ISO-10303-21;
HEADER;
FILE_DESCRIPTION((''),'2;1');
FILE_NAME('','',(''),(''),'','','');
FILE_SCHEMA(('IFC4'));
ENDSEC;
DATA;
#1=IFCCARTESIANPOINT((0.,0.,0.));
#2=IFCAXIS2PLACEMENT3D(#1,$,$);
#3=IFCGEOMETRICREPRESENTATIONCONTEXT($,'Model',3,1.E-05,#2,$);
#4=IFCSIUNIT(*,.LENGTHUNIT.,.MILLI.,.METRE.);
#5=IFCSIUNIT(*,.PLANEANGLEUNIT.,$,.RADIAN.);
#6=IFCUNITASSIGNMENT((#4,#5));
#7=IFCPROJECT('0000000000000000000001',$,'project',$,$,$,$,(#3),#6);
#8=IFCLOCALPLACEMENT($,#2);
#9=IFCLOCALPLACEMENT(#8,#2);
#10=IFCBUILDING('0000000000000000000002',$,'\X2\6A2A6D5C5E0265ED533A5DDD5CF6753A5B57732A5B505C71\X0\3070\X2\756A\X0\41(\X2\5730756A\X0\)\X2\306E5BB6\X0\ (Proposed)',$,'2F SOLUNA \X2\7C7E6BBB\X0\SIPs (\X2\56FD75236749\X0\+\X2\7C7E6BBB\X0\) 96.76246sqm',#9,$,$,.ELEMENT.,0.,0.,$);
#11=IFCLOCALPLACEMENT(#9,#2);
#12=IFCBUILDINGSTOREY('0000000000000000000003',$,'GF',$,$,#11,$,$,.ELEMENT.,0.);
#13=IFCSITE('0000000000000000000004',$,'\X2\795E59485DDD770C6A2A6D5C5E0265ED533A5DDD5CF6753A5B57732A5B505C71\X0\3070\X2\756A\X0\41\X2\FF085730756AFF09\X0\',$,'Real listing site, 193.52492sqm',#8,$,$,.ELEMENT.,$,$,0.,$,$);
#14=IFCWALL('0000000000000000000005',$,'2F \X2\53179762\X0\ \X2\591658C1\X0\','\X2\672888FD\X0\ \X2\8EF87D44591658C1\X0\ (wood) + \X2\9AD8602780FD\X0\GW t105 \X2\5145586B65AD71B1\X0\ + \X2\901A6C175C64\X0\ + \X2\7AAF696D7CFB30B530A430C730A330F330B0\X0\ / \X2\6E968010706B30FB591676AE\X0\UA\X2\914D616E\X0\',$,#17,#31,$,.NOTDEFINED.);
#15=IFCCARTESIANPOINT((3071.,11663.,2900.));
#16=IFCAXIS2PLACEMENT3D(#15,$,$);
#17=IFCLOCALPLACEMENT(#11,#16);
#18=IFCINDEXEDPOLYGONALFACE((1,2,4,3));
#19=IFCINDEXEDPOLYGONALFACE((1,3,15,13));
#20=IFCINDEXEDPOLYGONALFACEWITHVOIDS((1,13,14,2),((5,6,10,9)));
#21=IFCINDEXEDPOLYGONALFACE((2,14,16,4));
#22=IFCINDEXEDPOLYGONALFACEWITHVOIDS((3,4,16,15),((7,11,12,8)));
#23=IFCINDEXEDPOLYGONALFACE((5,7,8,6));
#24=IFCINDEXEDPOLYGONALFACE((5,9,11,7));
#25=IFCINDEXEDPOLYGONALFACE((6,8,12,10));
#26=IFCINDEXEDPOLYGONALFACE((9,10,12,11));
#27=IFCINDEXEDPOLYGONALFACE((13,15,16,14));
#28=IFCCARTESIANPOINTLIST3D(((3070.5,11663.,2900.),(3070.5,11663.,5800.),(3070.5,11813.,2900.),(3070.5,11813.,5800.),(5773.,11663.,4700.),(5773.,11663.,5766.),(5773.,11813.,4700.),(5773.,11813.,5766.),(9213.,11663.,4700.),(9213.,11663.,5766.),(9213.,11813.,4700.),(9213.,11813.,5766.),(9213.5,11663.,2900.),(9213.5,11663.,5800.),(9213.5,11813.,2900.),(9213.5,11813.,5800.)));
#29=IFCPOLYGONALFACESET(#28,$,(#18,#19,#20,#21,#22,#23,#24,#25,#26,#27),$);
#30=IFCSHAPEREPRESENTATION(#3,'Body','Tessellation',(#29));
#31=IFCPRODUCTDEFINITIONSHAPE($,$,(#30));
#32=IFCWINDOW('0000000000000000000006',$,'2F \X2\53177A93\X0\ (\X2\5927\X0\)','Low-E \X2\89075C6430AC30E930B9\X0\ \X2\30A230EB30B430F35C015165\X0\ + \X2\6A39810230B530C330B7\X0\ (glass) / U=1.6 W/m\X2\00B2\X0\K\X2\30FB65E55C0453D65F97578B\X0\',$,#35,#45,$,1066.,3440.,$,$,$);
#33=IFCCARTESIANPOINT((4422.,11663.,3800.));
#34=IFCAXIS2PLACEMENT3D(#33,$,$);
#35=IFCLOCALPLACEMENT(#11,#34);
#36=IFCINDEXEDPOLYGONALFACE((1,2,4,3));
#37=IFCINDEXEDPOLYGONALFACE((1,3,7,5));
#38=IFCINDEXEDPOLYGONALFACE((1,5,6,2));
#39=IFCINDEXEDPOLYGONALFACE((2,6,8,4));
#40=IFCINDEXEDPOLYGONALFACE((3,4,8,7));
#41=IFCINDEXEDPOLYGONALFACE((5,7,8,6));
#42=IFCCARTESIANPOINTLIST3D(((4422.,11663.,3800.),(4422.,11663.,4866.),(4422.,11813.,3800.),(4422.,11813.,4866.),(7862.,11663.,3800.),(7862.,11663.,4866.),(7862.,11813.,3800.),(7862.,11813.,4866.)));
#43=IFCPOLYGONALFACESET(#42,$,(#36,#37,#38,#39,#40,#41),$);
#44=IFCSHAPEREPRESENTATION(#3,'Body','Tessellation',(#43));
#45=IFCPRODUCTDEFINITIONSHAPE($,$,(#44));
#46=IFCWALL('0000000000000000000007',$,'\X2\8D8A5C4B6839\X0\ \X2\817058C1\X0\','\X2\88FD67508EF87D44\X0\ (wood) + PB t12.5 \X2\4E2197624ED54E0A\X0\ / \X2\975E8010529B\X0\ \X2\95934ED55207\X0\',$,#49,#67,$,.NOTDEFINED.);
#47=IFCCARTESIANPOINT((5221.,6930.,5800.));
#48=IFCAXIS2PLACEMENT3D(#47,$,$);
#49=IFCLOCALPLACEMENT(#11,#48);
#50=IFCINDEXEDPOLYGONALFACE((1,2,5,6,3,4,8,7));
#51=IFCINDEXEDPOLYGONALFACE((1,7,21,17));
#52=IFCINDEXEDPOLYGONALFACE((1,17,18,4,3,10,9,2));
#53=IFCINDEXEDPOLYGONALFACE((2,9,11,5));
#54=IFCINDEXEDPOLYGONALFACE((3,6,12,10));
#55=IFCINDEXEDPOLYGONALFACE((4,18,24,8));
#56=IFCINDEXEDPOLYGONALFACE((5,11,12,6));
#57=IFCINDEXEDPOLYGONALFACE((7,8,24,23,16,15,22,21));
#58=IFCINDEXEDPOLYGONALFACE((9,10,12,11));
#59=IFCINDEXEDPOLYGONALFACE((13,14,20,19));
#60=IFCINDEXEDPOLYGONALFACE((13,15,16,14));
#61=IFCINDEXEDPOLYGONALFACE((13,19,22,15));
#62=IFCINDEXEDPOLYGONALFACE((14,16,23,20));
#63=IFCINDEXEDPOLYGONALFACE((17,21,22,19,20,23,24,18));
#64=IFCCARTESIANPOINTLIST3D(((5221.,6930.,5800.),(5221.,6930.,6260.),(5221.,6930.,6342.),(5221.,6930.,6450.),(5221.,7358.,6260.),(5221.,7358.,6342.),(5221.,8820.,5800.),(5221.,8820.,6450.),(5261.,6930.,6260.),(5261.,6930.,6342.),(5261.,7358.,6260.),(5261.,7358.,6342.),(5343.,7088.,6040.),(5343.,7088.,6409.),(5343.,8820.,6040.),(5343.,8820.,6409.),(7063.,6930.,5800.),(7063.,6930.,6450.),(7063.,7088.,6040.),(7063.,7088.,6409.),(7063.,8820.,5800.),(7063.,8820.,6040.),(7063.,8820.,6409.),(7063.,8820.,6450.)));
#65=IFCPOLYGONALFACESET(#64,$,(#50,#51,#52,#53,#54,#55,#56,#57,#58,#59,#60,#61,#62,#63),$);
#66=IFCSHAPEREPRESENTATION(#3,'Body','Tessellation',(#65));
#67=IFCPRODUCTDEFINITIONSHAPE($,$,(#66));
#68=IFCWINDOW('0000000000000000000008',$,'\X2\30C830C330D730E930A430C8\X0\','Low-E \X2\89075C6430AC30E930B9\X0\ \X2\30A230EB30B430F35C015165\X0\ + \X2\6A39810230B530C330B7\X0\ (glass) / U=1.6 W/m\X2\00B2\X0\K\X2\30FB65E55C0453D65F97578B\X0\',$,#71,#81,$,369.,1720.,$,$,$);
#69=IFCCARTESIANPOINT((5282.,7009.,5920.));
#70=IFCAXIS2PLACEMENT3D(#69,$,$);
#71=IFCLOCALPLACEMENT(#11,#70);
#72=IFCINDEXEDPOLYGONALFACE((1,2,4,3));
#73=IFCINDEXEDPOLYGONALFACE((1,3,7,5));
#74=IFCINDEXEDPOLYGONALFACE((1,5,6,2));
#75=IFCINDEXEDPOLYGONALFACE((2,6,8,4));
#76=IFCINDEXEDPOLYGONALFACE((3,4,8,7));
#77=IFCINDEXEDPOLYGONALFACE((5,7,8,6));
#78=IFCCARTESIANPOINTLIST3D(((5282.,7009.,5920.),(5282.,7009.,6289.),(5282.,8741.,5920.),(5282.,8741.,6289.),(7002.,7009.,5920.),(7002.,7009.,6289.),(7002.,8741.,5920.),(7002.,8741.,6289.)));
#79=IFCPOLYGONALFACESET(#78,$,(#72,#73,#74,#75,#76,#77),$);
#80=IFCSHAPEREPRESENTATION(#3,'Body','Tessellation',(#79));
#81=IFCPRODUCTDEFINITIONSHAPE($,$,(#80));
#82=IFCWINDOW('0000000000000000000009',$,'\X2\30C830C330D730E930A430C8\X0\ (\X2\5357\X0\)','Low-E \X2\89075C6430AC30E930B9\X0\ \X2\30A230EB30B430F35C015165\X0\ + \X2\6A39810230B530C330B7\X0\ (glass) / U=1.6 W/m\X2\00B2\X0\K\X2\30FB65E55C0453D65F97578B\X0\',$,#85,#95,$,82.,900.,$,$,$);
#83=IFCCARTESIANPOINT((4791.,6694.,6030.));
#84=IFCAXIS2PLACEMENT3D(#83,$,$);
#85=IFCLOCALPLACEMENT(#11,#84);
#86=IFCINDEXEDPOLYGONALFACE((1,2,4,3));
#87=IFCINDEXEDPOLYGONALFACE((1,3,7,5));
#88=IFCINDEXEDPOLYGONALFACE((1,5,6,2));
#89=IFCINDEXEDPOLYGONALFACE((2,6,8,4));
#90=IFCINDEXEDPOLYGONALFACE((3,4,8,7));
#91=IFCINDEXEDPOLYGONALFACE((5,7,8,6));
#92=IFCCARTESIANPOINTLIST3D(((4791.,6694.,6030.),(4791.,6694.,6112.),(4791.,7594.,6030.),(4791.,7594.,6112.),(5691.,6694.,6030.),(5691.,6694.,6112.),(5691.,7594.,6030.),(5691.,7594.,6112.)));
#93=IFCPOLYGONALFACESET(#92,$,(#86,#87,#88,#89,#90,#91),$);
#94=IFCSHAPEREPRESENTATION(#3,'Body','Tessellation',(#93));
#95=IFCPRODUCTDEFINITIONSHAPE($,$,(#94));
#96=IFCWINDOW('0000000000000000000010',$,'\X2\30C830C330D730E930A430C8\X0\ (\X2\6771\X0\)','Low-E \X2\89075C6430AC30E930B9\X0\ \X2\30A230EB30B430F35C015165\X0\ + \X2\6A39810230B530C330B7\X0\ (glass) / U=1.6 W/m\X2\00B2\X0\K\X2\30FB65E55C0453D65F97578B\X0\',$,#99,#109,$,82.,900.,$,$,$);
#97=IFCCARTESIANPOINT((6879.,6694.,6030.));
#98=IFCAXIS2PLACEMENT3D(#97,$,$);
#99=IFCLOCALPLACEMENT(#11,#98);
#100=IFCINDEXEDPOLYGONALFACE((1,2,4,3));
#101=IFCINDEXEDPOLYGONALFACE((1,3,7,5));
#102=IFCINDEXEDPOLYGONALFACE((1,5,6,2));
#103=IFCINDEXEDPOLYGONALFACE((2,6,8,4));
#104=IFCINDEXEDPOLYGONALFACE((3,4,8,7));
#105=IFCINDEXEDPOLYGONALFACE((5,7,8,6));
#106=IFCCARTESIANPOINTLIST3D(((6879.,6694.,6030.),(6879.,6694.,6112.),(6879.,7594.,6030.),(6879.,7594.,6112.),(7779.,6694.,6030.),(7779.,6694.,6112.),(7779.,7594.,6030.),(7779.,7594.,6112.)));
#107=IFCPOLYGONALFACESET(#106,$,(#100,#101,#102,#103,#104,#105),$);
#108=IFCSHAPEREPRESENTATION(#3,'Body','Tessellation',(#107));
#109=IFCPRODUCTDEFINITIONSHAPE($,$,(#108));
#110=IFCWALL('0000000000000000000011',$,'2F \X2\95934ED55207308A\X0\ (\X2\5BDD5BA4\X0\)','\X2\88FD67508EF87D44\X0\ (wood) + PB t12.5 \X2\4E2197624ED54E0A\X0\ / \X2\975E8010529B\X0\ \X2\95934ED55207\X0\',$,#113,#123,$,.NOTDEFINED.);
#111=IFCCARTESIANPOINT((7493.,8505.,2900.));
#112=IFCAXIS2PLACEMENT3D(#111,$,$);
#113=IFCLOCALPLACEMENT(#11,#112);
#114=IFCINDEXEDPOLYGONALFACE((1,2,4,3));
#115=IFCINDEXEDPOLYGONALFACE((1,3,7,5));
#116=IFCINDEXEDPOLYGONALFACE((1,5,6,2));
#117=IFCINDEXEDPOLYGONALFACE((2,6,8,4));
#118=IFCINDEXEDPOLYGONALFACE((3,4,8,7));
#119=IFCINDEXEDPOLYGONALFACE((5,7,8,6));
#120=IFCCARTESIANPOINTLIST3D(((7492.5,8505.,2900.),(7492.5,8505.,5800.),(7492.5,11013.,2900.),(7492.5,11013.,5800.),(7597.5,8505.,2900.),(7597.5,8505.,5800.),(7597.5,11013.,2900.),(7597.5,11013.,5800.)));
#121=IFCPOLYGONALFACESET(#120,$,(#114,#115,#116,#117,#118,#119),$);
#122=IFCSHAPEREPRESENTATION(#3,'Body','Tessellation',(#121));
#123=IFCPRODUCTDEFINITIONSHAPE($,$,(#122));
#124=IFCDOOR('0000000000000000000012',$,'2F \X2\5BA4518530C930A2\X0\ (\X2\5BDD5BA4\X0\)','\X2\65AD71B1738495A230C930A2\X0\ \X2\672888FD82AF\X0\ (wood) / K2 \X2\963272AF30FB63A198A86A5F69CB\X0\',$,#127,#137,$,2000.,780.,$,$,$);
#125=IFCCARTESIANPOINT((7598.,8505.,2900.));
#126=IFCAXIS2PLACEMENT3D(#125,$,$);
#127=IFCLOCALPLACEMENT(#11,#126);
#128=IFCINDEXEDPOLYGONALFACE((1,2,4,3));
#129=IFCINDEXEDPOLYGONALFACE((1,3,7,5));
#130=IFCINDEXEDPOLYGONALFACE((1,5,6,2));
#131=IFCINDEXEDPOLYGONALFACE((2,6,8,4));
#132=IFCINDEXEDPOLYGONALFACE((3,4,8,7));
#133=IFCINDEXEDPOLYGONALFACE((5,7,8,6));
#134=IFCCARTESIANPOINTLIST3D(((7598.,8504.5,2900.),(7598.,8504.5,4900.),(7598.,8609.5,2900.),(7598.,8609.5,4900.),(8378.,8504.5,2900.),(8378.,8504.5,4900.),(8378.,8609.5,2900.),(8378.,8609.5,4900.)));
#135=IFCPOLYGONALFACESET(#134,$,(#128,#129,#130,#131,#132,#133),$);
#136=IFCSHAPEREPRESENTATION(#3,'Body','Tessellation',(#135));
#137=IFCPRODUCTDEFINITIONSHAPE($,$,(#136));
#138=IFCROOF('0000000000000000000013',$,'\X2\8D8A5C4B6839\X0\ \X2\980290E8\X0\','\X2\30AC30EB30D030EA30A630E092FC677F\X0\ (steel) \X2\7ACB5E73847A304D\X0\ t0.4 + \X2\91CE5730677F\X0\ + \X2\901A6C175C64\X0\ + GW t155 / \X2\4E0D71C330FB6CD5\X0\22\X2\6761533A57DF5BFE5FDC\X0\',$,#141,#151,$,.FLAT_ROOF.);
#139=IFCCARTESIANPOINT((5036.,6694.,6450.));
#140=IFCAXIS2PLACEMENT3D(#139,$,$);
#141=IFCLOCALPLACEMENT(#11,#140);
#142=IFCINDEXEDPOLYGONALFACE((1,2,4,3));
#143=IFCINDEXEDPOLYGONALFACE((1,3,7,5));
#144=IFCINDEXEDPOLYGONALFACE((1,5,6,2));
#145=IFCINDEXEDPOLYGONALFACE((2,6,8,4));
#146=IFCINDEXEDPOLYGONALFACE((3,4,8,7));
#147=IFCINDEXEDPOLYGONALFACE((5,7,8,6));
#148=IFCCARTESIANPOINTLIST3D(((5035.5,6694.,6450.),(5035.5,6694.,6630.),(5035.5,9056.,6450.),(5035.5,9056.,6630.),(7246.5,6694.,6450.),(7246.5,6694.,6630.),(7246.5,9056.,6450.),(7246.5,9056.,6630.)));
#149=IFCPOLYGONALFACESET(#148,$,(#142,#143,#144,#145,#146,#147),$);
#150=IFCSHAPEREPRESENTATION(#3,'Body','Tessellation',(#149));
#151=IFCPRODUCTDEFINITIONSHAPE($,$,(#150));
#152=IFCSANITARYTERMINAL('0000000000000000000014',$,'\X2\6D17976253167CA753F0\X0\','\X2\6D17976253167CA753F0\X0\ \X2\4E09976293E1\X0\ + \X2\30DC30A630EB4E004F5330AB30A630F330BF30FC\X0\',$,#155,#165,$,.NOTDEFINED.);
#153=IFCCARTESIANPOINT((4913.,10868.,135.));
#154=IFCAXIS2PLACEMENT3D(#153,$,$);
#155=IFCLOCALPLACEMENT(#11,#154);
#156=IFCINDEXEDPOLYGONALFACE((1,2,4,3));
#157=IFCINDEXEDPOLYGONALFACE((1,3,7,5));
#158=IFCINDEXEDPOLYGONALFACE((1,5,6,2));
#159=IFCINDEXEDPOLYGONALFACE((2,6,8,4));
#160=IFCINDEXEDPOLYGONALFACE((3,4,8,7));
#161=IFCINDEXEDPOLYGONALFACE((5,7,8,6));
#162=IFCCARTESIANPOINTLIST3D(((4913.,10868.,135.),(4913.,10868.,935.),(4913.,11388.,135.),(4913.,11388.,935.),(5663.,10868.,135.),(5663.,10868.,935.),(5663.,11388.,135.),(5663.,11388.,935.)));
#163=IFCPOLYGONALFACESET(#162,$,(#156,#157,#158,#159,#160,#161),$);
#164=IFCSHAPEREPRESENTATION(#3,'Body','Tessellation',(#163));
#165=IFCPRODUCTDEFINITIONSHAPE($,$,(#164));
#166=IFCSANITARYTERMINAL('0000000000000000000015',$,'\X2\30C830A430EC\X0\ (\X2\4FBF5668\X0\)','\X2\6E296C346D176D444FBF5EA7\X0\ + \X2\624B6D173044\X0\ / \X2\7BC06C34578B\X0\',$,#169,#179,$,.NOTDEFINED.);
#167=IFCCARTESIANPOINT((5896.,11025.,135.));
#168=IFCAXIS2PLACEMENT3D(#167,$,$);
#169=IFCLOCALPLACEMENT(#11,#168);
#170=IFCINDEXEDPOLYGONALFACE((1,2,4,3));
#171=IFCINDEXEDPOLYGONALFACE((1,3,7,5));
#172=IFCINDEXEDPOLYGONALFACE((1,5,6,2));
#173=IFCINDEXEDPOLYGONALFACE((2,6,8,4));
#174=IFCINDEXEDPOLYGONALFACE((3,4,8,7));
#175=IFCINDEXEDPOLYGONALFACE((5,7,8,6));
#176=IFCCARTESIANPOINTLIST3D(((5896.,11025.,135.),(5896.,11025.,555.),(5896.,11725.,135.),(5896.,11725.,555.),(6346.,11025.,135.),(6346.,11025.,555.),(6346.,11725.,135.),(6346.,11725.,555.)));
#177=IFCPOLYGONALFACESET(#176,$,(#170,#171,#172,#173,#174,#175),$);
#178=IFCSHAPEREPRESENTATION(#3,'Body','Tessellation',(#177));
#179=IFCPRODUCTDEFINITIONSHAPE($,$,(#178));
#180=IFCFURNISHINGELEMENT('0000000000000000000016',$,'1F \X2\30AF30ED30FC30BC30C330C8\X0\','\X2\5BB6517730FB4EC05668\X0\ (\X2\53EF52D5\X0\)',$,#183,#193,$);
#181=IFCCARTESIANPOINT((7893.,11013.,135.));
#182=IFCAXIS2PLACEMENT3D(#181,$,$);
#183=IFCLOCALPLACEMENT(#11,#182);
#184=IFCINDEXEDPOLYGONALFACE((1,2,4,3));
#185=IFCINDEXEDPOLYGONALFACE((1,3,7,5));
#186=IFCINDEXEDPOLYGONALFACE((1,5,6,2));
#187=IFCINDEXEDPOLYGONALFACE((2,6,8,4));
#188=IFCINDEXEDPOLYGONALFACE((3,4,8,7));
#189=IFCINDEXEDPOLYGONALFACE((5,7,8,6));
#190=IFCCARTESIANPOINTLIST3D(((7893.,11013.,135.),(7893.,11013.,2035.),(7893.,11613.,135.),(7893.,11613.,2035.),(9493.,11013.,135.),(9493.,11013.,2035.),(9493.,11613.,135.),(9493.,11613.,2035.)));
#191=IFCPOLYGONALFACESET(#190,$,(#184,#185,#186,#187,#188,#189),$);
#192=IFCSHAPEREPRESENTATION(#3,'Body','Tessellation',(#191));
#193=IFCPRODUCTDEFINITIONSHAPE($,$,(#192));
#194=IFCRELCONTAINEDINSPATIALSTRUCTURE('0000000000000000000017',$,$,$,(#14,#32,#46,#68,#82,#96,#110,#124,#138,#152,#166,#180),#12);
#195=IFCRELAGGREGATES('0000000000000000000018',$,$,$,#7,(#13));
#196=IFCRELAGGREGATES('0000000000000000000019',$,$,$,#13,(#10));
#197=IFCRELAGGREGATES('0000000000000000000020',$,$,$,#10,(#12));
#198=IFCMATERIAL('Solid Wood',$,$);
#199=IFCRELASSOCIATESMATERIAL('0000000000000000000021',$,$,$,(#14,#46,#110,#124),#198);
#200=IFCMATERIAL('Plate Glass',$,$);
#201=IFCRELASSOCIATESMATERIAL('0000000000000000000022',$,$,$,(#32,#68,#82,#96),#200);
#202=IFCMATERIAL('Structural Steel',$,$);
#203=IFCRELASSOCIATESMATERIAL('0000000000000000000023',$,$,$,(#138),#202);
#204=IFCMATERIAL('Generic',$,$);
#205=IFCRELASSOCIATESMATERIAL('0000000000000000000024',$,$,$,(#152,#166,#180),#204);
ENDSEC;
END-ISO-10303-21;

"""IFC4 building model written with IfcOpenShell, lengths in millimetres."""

from ifc_helpers import new_model, si_unit, frame, frame_2d, origin, place, context, project, spatial, rectangle, extrude, material, element, fill, save


model = new_model("IFC4")

# Units and contexts
model_context = context("Model", 3, precision=1e-05, world=origin())
ifc_project = project(units=[si_unit("LENGTHUNIT", "METRE", prefix="MILLI"), si_unit("PLANEANGLEUNIT", "RADIAN")], contexts=[model_context])

# Site, building, storey
site_placement = place(None, origin())
site = spatial("IfcSite", under=ifc_project, at=site_placement, Name="神奈川県横浜市旭区川島町字猪子山3070番41（地番）", ObjectType="Real listing site, 193.52492sqm", CompositionType="ELEMENT", RefElevation=0.0)
building_placement = place(site_placement, origin())
building = spatial("IfcBuilding", under=site, at=building_placement, Name="横浜市旭区川島町字猪子山3070番41(地番)の家 (Proposed)", ObjectType="2F SOLUNA 籾殻SIPs (国産杉+籾殻) 96.76246sqm", CompositionType="ELEMENT", ElevationOfRefHeight=0.0, ElevationOfTerrain=0.0)
storey_placement = place(building_placement, origin())
storey = spatial("IfcBuildingStorey", under=building, at=storey_placement, Name="GF", CompositionType="ELEMENT", Elevation=0.0)

# Wall, opening, window
ifc_material_1 = material(Name="Solid Wood")
wall_1_placement = place(storey_placement, frame((3071.0, 11663.0, 2900.0)))
wall_1 = element("IfcWall", 1, at=wall_1_placement, inside=storey, material=ifc_material_1, Name="2F 北面 外壁", Description="木製 軸組外壁 (wood) + 高性能GW t105 充填断熱 + 通気層 + 窯業系サイディング / 準耐火・外皮UA配慮", PredefinedType="NOTDEFINED", context=model_context, shape_type="SweptSolid", body=[
    extrude(rectangle(XDim=6143.0, YDim=150.0, at=frame_2d((3071.0, 75.0))), frame((3071.0, 11663.0, 2900.0)), (0.0, 0.0, 1.0), 2900.0),
])
opening_1_placement = place(storey_placement, frame((4422.0, 11663.0, 3800.0)))
opening_1 = element("IfcOpeningElement", 2, at=opening_1_placement, cuts=wall_1, PredefinedType="NOTDEFINED", context=model_context, shape_type="SweptSolid", body=[
    extrude(rectangle(XDim=3440.0, YDim=150.0, at=frame_2d((1720.0, 75.0))), frame((4422.0, 11663.0, 3800.0)), (0.0, 0.0, 1.0), 1066.0),
])
ifc_material_2 = material(Name="Plate Glass")
window_1_placement = place(storey_placement, frame((4422.0, 11663.0, 3800.0)))
window_1 = element("IfcWindow", 3, at=window_1_placement, inside=storey, material=ifc_material_2, Name="2F 北窓 (大)", Description="Low-E 複層ガラス アルゴン封入 + 樹脂サッシ (glass) / U=1.6 W/m²K・日射取得型", OverallHeight=1066.0, OverallWidth=3440.0, context=model_context, shape_type="SweptSolid", body=[
    extrude(rectangle(XDim=3440.0, YDim=150.0, at=frame_2d((1720.0, 75.0))), frame((4422.0, 11663.0, 3800.0)), (0.0, 0.0, 1.0), 1066.0),
])
fill(opening_1, window_1)

# Wall, openings, windows
wall_2_placement = place(storey_placement, frame((5221.0, 6930.0, 5800.0)))
wall_2 = element("IfcWall", 4, at=wall_2_placement, inside=storey, material=ifc_material_1, Name="越屋根 腰壁", Description="製材軸組 (wood) + PB t12.5 両面仕上 / 非耐力 間仕切", PredefinedType="NOTDEFINED", context=model_context, shape_type="SweptSolid", body=[
    extrude(rectangle(XDim=1842.0, YDim=1890.0, at=frame_2d((921.0, 945.0))), frame((5221.0, 6930.0, 5800.0)), (0.0, 0.0, 1.0), 650.0),
])
opening_2_placement = place(storey_placement, frame((5282.0, 7009.0, 5920.0)))
opening_2 = element("IfcOpeningElement", 5, at=opening_2_placement, cuts=wall_2, PredefinedType="NOTDEFINED", context=model_context, shape_type="SweptSolid", body=[
    extrude(rectangle(XDim=1720.0, YDim=1732.0, at=frame_2d((860.0, 866.0))), frame((5282.0, 7009.0, 5920.0)), (0.0, 0.0, 1.0), 369.0),
])
opening_3_placement = place(storey_placement, frame((4791.0, 6694.0, 6030.0)))
opening_3 = element("IfcOpeningElement", 6, at=opening_3_placement, cuts=wall_2, PredefinedType="NOTDEFINED", context=model_context, shape_type="SweptSolid", body=[
    extrude(rectangle(XDim=900.0, YDim=900.0, at=frame_2d((450.0, 450.0))), frame((4791.0, 6694.0, 6030.0)), (0.0, 0.0, 1.0), 82.0),
])
opening_4_placement = place(storey_placement, frame((6879.0, 6694.0, 6030.0)))
opening_4 = element("IfcOpeningElement", 7, at=opening_4_placement, cuts=wall_2, PredefinedType="NOTDEFINED", context=model_context, shape_type="SweptSolid", body=[
    extrude(rectangle(XDim=900.0, YDim=900.0, at=frame_2d((450.0, 450.0))), frame((6879.0, 6694.0, 6030.0)), (0.0, 0.0, 1.0), 82.0),
])
window_2_placement = place(storey_placement, frame((5282.0, 7009.0, 5920.0)))
window_2 = element("IfcWindow", 8, at=window_2_placement, inside=storey, material=ifc_material_2, Name="トップライト", Description="Low-E 複層ガラス アルゴン封入 + 樹脂サッシ (glass) / U=1.6 W/m²K・日射取得型", OverallHeight=369.0, OverallWidth=1720.0, context=model_context, shape_type="SweptSolid", body=[
    extrude(rectangle(XDim=1720.0, YDim=1732.0, at=frame_2d((860.0, 866.0))), frame((5282.0, 7009.0, 5920.0)), (0.0, 0.0, 1.0), 369.0),
])
fill(opening_2, window_2)
window_3_placement = place(storey_placement, frame((4791.0, 6694.0, 6030.0)))
window_3 = element("IfcWindow", 9, at=window_3_placement, inside=storey, material=ifc_material_2, Name="トップライト (南)", Description="Low-E 複層ガラス アルゴン封入 + 樹脂サッシ (glass) / U=1.6 W/m²K・日射取得型", OverallHeight=82.0, OverallWidth=900.0, context=model_context, shape_type="SweptSolid", body=[
    extrude(rectangle(XDim=900.0, YDim=900.0, at=frame_2d((450.0, 450.0))), frame((4791.0, 6694.0, 6030.0)), (0.0, 0.0, 1.0), 82.0),
])
fill(opening_3, window_3)
window_4_placement = place(storey_placement, frame((6879.0, 6694.0, 6030.0)))
window_4 = element("IfcWindow", 10, at=window_4_placement, inside=storey, material=ifc_material_2, Name="トップライト (東)", Description="Low-E 複層ガラス アルゴン封入 + 樹脂サッシ (glass) / U=1.6 W/m²K・日射取得型", OverallHeight=82.0, OverallWidth=900.0, context=model_context, shape_type="SweptSolid", body=[
    extrude(rectangle(XDim=900.0, YDim=900.0, at=frame_2d((450.0, 450.0))), frame((6879.0, 6694.0, 6030.0)), (0.0, 0.0, 1.0), 82.0),
])
fill(opening_4, window_4)

# Wall
wall_3_placement = place(storey_placement, frame((7493.0, 8505.0, 2900.0)))
element("IfcWall", 11, at=wall_3_placement, inside=storey, material=ifc_material_1, Name="2F 間仕切り (寝室)", Description="製材軸組 (wood) + PB t12.5 両面仕上 / 非耐力 間仕切", PredefinedType="NOTDEFINED", context=model_context, shape_type="SweptSolid", body=[
    extrude(rectangle(XDim=105.0, YDim=2508.0, at=frame_2d((52.0, 1254.0))), frame((7493.0, 8505.0, 2900.0)), (0.0, 0.0, 1.0), 2900.0),
])

# Door
door_placement = place(storey_placement, frame((7598.0, 8505.0, 2900.0)))
element("IfcDoor", 12, at=door_placement, inside=storey, material=ifc_material_1, Name="2F 室内ドア (寝室)", Description="断熱玄関ドア 木製芯 (wood) / K2 防犯・採風機構", OverallHeight=2000.0, OverallWidth=780.0, context=model_context, shape_type="SweptSolid", body=[
    extrude(rectangle(XDim=780.0, YDim=105.0, at=frame_2d((390.0, 52.0))), frame((7598.0, 8505.0, 2900.0)), (0.0, 0.0, 1.0), 2000.0),
])

# Roof
ifc_material_3 = material(Name="Structural Steel")
roof_placement = place(storey_placement, frame((5036.0, 6694.0, 6450.0)))
element("IfcRoof", 13, at=roof_placement, inside=storey, material=ifc_material_3, Name="越屋根 頂部", Description="ガルバリウム鋼板 (steel) 立平葺き t0.4 + 野地板 + 通気層 + GW t155 / 不燃・法22条区域対応", PredefinedType="FLAT_ROOF", context=model_context, shape_type="SweptSolid", body=[
    extrude(rectangle(XDim=2211.0, YDim=2362.0, at=frame_2d((1105.0, 1181.0))), frame((5036.0, 6694.0, 6450.0)), (0.0, 0.0, 1.0), 180.0),
])

# Sanitary terminals
ifc_material_4 = material(Name="Generic")
sanitary_terminal_1_placement = place(storey_placement, frame((4913.0, 10868.0, 135.0)))
element("IfcSanitaryTerminal", 14, at=sanitary_terminal_1_placement, inside=storey, material=ifc_material_4, Name="洗面化粧台", Description="洗面化粧台 三面鏡 + ボウル一体カウンター", PredefinedType="NOTDEFINED", context=model_context, shape_type="SweptSolid", body=[
    extrude(rectangle(XDim=750.0, YDim=520.0, at=frame_2d((375.0, 260.0))), frame((4913.0, 10868.0, 135.0)), (0.0, 0.0, 1.0), 800.0),
])
sanitary_terminal_2_placement = place(storey_placement, frame((5896.0, 11025.0, 135.0)))
element("IfcSanitaryTerminal", 15, at=sanitary_terminal_2_placement, inside=storey, material=ifc_material_4, Name="トイレ (便器)", Description="温水洗浄便座 + 手洗い / 節水型", PredefinedType="NOTDEFINED", context=model_context, shape_type="SweptSolid", body=[
    extrude(rectangle(XDim=450.0, YDim=700.0, at=frame_2d((225.0, 350.0))), frame((5896.0, 11025.0, 135.0)), (0.0, 0.0, 1.0), 420.0),
])

# Furnishing element
furnishing_1_placement = place(storey_placement, frame((7893.0, 11013.0, 135.0)))
element("IfcFurnishingElement", 16, at=furnishing_1_placement, inside=storey, material=ifc_material_4, Name="1F クローゼット", Description="家具・什器 (可動)", context=model_context, shape_type="SweptSolid", body=[
    extrude(rectangle(XDim=1600.0, YDim=600.0, at=frame_2d((800.0, 300.0))), frame((7893.0, 11013.0, 135.0)), (0.0, 0.0, 1.0), 1900.0),
])

save(model, "model.ifc")
